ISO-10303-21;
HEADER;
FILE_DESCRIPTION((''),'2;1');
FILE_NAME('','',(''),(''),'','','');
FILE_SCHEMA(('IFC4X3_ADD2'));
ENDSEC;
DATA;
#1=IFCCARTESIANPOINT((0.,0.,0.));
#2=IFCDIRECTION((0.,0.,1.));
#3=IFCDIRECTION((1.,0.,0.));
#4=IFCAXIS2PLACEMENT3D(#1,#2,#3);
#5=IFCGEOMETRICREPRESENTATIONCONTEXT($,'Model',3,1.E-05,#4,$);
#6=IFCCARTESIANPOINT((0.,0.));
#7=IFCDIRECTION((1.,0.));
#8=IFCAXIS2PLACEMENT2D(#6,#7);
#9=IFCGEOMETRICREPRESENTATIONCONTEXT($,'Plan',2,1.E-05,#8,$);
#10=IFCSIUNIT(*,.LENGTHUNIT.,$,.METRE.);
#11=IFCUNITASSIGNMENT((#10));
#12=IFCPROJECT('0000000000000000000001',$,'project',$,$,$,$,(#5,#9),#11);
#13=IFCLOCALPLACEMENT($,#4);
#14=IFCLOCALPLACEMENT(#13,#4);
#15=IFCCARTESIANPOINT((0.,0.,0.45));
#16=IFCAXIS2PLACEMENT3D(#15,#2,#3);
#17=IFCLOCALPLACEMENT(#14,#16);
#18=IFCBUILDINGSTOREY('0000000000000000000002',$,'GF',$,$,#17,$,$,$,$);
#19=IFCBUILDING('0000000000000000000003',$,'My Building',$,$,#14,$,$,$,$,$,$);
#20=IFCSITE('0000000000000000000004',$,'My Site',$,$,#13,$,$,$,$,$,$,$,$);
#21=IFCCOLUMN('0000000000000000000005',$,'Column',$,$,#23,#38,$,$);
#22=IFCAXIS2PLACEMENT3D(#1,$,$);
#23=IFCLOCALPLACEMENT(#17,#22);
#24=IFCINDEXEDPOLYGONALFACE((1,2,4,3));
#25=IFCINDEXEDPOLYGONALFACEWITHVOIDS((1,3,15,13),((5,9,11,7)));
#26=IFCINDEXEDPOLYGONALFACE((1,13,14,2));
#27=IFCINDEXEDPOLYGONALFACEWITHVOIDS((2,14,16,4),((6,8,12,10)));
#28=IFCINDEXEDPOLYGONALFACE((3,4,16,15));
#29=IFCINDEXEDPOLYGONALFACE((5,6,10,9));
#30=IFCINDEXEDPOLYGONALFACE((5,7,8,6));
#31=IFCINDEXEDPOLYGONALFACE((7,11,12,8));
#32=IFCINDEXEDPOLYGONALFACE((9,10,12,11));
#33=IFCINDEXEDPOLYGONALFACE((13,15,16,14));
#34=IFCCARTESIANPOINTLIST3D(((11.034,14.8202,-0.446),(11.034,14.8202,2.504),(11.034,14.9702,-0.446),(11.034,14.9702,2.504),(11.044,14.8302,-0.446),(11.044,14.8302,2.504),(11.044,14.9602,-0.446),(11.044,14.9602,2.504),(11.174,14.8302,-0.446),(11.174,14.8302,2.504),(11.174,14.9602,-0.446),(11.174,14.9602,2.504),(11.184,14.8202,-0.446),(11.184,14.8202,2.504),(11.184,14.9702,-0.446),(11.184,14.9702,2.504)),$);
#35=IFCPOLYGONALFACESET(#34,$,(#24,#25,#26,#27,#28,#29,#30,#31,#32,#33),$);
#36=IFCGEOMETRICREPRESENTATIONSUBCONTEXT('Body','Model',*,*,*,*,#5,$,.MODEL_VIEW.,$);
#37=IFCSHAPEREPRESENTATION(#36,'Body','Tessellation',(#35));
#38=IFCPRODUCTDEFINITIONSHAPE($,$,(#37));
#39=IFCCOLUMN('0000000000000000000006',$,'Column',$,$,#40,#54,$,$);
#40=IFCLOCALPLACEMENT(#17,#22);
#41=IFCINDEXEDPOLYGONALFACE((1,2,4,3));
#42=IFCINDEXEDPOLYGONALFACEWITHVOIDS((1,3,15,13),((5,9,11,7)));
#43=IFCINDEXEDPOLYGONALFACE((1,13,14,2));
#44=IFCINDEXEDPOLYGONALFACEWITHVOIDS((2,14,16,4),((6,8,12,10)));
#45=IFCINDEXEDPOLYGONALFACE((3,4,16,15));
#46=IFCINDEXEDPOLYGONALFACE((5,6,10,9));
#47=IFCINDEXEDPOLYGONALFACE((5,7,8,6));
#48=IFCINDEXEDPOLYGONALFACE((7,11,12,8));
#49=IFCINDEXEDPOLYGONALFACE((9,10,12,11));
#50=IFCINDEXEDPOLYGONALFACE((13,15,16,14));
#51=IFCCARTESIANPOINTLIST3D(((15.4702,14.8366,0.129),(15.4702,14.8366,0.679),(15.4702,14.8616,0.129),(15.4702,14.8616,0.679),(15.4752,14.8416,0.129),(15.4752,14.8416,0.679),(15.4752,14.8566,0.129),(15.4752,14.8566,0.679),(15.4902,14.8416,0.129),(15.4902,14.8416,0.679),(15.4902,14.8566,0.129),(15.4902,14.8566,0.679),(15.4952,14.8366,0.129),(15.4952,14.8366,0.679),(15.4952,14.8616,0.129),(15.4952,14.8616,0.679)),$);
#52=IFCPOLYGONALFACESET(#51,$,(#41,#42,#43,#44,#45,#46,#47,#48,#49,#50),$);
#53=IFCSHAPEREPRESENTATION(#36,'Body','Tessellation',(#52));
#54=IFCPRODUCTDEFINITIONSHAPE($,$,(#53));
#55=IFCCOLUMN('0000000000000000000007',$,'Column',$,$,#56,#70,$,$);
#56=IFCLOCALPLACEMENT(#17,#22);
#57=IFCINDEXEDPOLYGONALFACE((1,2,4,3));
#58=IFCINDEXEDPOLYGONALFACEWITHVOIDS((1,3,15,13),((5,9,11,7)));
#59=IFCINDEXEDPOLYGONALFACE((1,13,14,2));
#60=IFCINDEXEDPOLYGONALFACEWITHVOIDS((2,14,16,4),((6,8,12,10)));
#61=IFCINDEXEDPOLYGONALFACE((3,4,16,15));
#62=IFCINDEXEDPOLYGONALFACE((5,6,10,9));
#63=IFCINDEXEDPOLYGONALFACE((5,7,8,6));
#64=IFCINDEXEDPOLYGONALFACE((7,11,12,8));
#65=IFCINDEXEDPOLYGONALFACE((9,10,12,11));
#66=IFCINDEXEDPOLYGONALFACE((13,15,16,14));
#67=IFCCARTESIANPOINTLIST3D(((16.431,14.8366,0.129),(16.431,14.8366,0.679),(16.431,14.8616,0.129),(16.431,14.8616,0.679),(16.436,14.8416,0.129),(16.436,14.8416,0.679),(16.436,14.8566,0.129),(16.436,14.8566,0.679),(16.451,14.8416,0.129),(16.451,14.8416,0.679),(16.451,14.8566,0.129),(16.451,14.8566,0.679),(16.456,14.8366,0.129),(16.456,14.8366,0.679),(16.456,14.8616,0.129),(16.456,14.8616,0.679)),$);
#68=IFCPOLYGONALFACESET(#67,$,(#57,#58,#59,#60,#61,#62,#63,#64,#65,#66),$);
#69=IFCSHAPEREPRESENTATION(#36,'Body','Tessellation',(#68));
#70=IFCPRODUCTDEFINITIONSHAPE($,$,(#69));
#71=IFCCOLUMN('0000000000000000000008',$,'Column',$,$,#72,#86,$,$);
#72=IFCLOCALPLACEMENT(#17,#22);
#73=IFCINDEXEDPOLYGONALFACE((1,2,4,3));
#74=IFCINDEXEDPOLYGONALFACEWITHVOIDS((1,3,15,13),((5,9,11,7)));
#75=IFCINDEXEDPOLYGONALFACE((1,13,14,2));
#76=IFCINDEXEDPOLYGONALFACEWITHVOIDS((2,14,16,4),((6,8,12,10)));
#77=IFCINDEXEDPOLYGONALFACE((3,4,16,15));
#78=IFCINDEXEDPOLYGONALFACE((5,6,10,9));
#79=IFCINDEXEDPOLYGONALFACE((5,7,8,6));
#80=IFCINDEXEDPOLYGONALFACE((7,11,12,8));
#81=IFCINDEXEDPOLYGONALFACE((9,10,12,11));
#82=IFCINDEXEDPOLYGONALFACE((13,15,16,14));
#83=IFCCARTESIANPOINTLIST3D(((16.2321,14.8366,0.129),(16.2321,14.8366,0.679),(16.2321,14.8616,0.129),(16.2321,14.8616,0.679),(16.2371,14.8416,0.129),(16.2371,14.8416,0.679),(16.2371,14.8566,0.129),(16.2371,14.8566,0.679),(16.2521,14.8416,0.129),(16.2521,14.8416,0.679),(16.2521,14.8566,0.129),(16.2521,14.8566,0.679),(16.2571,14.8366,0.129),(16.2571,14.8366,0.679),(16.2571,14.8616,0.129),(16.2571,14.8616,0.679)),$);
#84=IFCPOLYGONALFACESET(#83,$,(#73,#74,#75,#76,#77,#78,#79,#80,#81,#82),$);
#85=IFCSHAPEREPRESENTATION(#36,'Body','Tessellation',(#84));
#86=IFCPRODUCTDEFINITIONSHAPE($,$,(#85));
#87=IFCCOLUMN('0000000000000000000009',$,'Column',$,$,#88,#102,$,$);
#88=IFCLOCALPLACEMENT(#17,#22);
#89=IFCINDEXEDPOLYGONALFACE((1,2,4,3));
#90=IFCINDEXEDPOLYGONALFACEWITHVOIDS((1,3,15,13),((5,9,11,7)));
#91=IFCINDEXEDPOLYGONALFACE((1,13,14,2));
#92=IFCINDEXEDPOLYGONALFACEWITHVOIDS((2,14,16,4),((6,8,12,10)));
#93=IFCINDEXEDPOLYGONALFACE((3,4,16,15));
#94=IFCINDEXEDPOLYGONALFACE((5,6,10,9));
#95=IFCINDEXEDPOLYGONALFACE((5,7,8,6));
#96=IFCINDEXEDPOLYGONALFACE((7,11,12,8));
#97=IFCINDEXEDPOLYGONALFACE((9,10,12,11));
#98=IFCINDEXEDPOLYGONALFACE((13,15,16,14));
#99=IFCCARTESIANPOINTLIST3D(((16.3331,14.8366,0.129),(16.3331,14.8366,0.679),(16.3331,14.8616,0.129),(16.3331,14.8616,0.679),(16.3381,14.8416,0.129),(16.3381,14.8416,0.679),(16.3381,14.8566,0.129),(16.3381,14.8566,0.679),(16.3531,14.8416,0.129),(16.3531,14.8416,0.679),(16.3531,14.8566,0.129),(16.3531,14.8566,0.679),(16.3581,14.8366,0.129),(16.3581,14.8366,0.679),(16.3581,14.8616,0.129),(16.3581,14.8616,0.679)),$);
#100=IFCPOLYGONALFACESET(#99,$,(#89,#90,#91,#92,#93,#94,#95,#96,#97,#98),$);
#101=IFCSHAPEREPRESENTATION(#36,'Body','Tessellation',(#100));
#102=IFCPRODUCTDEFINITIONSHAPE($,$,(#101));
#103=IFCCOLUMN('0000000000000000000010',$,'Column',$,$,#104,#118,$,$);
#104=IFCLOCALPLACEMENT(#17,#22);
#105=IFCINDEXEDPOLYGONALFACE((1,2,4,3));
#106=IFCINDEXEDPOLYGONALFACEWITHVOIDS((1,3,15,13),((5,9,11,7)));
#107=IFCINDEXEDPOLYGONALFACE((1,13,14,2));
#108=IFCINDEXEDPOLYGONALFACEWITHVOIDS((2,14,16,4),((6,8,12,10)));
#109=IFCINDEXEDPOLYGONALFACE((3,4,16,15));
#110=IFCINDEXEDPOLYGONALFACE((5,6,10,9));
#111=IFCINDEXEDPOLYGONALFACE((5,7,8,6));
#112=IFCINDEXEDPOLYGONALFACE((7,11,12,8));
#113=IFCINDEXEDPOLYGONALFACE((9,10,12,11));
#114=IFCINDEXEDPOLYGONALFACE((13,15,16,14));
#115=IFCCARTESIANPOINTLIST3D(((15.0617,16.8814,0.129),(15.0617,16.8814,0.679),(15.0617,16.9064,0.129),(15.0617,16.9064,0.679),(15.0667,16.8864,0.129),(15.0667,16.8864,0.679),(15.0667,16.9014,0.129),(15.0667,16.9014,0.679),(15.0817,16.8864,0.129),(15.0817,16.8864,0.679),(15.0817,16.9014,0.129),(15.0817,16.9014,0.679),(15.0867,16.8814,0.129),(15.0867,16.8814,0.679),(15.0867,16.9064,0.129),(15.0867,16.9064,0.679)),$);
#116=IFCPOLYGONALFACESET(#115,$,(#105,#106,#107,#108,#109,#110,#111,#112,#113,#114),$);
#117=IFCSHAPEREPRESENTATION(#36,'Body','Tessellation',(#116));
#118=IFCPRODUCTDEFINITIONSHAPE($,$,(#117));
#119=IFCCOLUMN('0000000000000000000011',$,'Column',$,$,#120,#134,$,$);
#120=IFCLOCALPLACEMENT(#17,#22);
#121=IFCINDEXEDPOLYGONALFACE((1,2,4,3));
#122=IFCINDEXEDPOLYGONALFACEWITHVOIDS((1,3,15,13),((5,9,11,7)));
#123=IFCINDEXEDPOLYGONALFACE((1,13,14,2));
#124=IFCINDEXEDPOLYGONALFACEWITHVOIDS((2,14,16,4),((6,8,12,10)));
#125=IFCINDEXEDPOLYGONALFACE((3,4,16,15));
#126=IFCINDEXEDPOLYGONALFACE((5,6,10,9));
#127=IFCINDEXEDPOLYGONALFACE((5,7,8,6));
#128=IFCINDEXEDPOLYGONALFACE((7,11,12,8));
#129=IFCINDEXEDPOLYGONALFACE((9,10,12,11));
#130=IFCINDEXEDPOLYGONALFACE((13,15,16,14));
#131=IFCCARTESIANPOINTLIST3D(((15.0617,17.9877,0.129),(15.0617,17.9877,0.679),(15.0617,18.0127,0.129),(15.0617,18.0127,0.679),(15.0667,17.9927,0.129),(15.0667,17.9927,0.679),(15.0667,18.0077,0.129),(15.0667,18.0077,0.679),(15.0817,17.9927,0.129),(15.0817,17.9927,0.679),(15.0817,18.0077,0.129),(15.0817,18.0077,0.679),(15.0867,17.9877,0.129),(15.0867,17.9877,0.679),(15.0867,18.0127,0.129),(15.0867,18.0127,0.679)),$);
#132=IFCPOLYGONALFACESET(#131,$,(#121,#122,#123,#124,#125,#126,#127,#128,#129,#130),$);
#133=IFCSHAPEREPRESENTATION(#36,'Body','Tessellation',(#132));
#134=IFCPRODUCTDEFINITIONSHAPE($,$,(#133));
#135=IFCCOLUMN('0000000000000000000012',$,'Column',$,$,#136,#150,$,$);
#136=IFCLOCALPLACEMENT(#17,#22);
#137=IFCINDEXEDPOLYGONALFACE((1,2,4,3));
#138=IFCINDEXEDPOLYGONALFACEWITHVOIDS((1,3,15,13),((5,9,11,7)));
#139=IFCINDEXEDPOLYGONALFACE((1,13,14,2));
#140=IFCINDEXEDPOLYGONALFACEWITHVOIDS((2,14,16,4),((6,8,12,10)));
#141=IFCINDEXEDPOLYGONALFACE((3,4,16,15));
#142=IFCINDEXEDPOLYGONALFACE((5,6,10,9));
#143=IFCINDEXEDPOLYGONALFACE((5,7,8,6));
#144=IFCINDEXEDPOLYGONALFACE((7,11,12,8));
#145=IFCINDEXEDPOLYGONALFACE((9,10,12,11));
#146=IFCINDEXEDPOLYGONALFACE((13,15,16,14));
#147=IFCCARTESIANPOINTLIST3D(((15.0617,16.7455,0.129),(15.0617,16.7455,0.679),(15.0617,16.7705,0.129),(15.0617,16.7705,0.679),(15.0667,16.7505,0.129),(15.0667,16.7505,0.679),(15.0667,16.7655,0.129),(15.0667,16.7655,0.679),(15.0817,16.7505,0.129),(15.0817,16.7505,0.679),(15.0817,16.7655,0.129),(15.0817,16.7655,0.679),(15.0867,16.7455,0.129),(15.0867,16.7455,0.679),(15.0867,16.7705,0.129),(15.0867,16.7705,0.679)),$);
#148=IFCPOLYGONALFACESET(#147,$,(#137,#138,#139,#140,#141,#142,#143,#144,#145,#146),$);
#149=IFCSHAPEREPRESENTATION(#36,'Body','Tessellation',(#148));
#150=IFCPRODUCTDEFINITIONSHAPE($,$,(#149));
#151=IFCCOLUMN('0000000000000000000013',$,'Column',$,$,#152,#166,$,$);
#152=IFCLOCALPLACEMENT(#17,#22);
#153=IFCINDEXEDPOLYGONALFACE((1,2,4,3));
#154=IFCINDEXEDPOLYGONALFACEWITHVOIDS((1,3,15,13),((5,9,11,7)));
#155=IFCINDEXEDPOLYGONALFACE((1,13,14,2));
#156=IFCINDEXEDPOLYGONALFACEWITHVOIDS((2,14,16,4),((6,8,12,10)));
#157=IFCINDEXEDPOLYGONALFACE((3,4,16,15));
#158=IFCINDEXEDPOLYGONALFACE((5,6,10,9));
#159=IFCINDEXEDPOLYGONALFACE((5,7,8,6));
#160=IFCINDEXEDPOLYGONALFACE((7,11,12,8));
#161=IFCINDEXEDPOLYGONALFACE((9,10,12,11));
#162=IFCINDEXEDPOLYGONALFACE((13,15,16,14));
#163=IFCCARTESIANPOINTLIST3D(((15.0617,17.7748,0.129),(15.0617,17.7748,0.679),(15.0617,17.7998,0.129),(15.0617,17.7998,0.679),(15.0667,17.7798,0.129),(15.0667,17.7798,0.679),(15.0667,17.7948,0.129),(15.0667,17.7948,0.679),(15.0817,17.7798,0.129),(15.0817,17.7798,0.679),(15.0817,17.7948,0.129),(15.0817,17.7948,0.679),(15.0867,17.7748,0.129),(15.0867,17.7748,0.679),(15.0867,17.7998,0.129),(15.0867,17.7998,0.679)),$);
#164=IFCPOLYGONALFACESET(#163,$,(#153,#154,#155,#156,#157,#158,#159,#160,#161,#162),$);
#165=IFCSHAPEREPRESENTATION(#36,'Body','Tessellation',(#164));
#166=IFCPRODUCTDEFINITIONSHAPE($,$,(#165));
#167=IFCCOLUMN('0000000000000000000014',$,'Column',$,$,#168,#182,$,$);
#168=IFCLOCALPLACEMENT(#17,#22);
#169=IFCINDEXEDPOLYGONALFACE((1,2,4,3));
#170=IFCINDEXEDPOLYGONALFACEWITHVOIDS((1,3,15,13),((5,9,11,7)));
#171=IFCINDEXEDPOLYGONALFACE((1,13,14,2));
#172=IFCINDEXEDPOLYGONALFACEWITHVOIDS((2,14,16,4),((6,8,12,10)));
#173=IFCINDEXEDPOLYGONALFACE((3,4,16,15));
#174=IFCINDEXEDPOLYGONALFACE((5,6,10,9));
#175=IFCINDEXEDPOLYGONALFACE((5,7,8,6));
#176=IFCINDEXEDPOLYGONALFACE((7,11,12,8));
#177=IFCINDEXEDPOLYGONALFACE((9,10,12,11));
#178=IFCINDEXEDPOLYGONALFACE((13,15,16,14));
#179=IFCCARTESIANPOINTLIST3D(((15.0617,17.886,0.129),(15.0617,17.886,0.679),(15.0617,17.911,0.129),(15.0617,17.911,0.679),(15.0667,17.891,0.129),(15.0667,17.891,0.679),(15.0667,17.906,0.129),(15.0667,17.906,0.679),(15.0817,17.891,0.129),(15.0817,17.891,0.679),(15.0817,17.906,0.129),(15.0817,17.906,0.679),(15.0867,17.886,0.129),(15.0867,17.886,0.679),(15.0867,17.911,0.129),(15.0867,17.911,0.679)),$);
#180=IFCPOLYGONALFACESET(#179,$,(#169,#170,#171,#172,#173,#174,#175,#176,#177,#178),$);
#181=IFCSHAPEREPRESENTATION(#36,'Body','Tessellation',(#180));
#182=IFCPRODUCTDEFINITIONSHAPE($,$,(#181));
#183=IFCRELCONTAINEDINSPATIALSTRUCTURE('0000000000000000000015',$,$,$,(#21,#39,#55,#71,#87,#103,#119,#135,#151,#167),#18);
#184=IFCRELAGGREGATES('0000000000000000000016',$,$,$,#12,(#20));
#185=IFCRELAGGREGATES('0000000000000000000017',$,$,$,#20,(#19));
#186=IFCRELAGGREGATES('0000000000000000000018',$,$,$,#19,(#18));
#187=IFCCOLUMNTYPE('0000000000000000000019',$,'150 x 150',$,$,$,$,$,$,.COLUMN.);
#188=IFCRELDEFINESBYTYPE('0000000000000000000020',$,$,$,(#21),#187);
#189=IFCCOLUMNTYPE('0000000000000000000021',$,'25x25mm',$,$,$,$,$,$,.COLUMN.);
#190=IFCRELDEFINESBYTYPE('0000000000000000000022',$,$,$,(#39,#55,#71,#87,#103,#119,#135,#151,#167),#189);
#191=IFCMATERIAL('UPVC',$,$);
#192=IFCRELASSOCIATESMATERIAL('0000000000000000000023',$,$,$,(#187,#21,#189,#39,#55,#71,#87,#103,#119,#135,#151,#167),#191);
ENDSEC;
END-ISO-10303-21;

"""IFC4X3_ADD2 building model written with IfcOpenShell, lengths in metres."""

from ifc_helpers import new_model, entity, si_unit, frame, origin_with_axes, origin_2d_with_axis, place, context, subcontext, project, spatial, hollow_rectangle, extrude, shape, material, material_profile, profile_set, profile_usage, type_object, element, save


model = new_model("IFC4X3_ADD2")

# Units and contexts
model_context = context("Model", 3, precision=1e-05, world=origin_with_axes())
plan_context = context("Plan", 2, precision=1e-05, world=origin_2d_with_axis())
body_context_1 = subcontext(model_context, "Body", "Model", "MODEL_VIEW")
body_context_2 = subcontext(plan_context, "Body", "Plan", "PLAN_VIEW")
ifc_project = project(units=[si_unit("LENGTHUNIT", "METRE")], contexts=[model_context, plan_context])

# Site, building, storey
site_placement = place(None, origin_with_axes())
site = spatial("IfcSite", under=ifc_project, at=site_placement, Name="My Site")
building_placement = place(site_placement, origin_with_axes())
building = spatial("IfcBuilding", under=site, at=building_placement, Name="My Building")
storey_placement = place(building_placement, frame((0.0, 0.0, 0.45), z_axis=(0.0, 0.0, 1.0), x_axis=(1.0, 0.0, 0.0)))
storey = spatial("IfcBuildingStorey", under=building, at=storey_placement, Name="GF")

# Columns
ifc_material_1 = material(Name="UPVC")
ifc_material_profile_1 = material_profile(ifc_material_1, hollow_rectangle(XDim=0.15, YDim=0.15, WallThickness=0.01))
ifc_profile_set_1 = profile_set([ifc_material_profile_1])
ifc_profile_usage_1 = profile_usage(ifc_profile_set_1)
column_type_1 = type_object("IfcColumnType", Name="150 x 150", PredefinedType="COLUMN", material=ifc_profile_set_1)
column_1_placement = place(storey_placement, frame((11.109, 14.8952, -0.446), z_axis=(0.0, 0.0, 1.0), x_axis=(1.0, 0.0, 0.0)))
element("IfcColumn", 1, at=column_1_placement, inside=storey, type_object=column_type_1, material=ifc_profile_usage_1, Name="Column", shapes=[
    shape(body_context_1, "Body", "SweptSolid", [extrude(hollow_rectangle(XDim=0.15, YDim=0.15, WallThickness=0.01), origin_with_axes(), (0.0, 0.0, 1.0), 2.95)]),
    shape(body_context_2, "Body", "Annotation2D", [entity("IfcGeometricCurveSet", [entity("IfcIndexedPolyCurve", entity("IfcCartesianPointList2D", [[-0.065, -0.065], [0.065, -0.065], [0.065, 0.065], [-0.065, 0.065]]), [entity("IfcLineIndex", [1, 2, 3, 4, 1])]), entity("IfcIndexedPolyCurve", entity("IfcCartesianPointList2D", [[0.075, -0.075], [-0.075, -0.075], [-0.075, 0.075], [0.075, 0.075]]), [entity("IfcLineIndex", [1, 2, 3, 4, 1])])])]),
])
ifc_material_profile_2 = material_profile(ifc_material_1, hollow_rectangle(XDim=0.025, YDim=0.025, WallThickness=0.005))
ifc_profile_set_2 = profile_set([ifc_material_profile_2])
ifc_profile_usage_2 = profile_usage(ifc_profile_set_2)
column_type_2 = type_object("IfcColumnType", Name="25x25mm", PredefinedType="COLUMN", material=ifc_profile_set_2)
column_2_placement = place(storey_placement, frame((15.4827, 14.8491, 0.129), z_axis=(0.0, 0.0, 1.0), x_axis=(0.0, -1.0, 0.0)))
element("IfcColumn", 2, at=column_2_placement, inside=storey, type_object=column_type_2, material=ifc_profile_usage_2, Name="Column", context=body_context_1, shape_type="SweptSolid", body=[
    extrude(hollow_rectangle(XDim=0.025, YDim=0.025, WallThickness=0.005), origin_with_axes(), (0.0, 0.0, 1.0), 0.55),
])
ifc_profile_usage_3 = profile_usage(ifc_profile_set_2)
column_3_placement = place(storey_placement, frame((16.4435, 14.8491, 0.129), z_axis=(0.0, 0.0, 1.0), x_axis=(0.0, -1.0, 0.0)))
element("IfcColumn", 3, at=column_3_placement, inside=storey, type_object=column_type_2, material=ifc_profile_usage_3, Name="Column", context=body_context_1, shape_type="SweptSolid", body=[
    extrude(hollow_rectangle(XDim=0.025, YDim=0.025, WallThickness=0.005), origin_with_axes(), (0.0, 0.0, 1.0), 0.55),
])
ifc_profile_usage_4 = profile_usage(ifc_profile_set_2)
column_4_placement = place(storey_placement, frame((16.2446, 14.8491, 0.129), z_axis=(0.0, 0.0, 1.0), x_axis=(0.0, -1.0, 0.0)))
element("IfcColumn", 4, at=column_4_placement, inside=storey, type_object=column_type_2, material=ifc_profile_usage_4, Name="Column", context=body_context_1, shape_type="SweptSolid", body=[
    extrude(hollow_rectangle(XDim=0.025, YDim=0.025, WallThickness=0.005), origin_with_axes(), (0.0, 0.0, 1.0), 0.55),
])
ifc_profile_usage_5 = profile_usage(ifc_profile_set_2)
column_5_placement = place(storey_placement, frame((16.3456, 14.8491, 0.129), z_axis=(0.0, 0.0, 1.0), x_axis=(0.0, -1.0, 0.0)))
element("IfcColumn", 5, at=column_5_placement, inside=storey, type_object=column_type_2, material=ifc_profile_usage_5, Name="Column", context=body_context_1, shape_type="SweptSolid", body=[
    extrude(hollow_rectangle(XDim=0.025, YDim=0.025, WallThickness=0.005), origin_with_axes(), (0.0, 0.0, 1.0), 0.55),
])
ifc_profile_usage_6 = profile_usage(ifc_profile_set_2)
column_6_placement = place(storey_placement, frame((15.0742, 16.8939, 0.129), z_axis=(0.0, 0.0, 1.0), x_axis=(0.0, -1.0, 0.0)))
element("IfcColumn", 6, at=column_6_placement, inside=storey, type_object=column_type_2, material=ifc_profile_usage_6, Name="Column", context=body_context_1, shape_type="SweptSolid", body=[
    extrude(hollow_rectangle(XDim=0.025, YDim=0.025, WallThickness=0.005), origin_with_axes(), (0.0, 0.0, 1.0), 0.55),
])
ifc_profile_usage_7 = profile_usage(ifc_profile_set_2)
column_7_placement = place(storey_placement, frame((15.0742, 18.0002, 0.129), z_axis=(0.0, 0.0, 1.0), x_axis=(0.0, -1.0, 0.0)))
element("IfcColumn", 7, at=column_7_placement, inside=storey, type_object=column_type_2, material=ifc_profile_usage_7, Name="Column", context=body_context_1, shape_type="SweptSolid", body=[
    extrude(hollow_rectangle(XDim=0.025, YDim=0.025, WallThickness=0.005), origin_with_axes(), (0.0, 0.0, 1.0), 0.55),
])
ifc_profile_usage_8 = profile_usage(ifc_profile_set_2)
column_8_placement = place(storey_placement, frame((15.0742, 16.758, 0.129), z_axis=(0.0, 0.0, 1.0), x_axis=(0.0, -1.0, 0.0)))
element("IfcColumn", 8, at=column_8_placement, inside=storey, type_object=column_type_2, material=ifc_profile_usage_8, Name="Column", context=body_context_1, shape_type="SweptSolid", body=[
    extrude(hollow_rectangle(XDim=0.025, YDim=0.025, WallThickness=0.005), origin_with_axes(), (0.0, 0.0, 1.0), 0.55),
])
ifc_profile_usage_9 = profile_usage(ifc_profile_set_2)
column_9_placement = place(storey_placement, frame((15.0742, 17.7873, 0.129), z_axis=(0.0, 0.0, 1.0), x_axis=(0.0, -1.0, 0.0)))
element("IfcColumn", 9, at=column_9_placement, inside=storey, type_object=column_type_2, material=ifc_profile_usage_9, Name="Column", context=body_context_1, shape_type="SweptSolid", body=[
    extrude(hollow_rectangle(XDim=0.025, YDim=0.025, WallThickness=0.005), origin_with_axes(), (0.0, 0.0, 1.0), 0.55),
])
ifc_profile_usage_10 = profile_usage(ifc_profile_set_2)
column_10_placement = place(storey_placement, frame((15.0742, 17.8985, 0.129), z_axis=(0.0, 0.0, 1.0), x_axis=(0.0, -1.0, 0.0)))
element("IfcColumn", 10, at=column_10_placement, inside=storey, type_object=column_type_2, material=ifc_profile_usage_10, Name="Column", context=body_context_1, shape_type="SweptSolid", body=[
    extrude(hollow_rectangle(XDim=0.025, YDim=0.025, WallThickness=0.005), origin_with_axes(), (0.0, 0.0, 1.0), 0.55),
])

save(model, "model.ifc")
